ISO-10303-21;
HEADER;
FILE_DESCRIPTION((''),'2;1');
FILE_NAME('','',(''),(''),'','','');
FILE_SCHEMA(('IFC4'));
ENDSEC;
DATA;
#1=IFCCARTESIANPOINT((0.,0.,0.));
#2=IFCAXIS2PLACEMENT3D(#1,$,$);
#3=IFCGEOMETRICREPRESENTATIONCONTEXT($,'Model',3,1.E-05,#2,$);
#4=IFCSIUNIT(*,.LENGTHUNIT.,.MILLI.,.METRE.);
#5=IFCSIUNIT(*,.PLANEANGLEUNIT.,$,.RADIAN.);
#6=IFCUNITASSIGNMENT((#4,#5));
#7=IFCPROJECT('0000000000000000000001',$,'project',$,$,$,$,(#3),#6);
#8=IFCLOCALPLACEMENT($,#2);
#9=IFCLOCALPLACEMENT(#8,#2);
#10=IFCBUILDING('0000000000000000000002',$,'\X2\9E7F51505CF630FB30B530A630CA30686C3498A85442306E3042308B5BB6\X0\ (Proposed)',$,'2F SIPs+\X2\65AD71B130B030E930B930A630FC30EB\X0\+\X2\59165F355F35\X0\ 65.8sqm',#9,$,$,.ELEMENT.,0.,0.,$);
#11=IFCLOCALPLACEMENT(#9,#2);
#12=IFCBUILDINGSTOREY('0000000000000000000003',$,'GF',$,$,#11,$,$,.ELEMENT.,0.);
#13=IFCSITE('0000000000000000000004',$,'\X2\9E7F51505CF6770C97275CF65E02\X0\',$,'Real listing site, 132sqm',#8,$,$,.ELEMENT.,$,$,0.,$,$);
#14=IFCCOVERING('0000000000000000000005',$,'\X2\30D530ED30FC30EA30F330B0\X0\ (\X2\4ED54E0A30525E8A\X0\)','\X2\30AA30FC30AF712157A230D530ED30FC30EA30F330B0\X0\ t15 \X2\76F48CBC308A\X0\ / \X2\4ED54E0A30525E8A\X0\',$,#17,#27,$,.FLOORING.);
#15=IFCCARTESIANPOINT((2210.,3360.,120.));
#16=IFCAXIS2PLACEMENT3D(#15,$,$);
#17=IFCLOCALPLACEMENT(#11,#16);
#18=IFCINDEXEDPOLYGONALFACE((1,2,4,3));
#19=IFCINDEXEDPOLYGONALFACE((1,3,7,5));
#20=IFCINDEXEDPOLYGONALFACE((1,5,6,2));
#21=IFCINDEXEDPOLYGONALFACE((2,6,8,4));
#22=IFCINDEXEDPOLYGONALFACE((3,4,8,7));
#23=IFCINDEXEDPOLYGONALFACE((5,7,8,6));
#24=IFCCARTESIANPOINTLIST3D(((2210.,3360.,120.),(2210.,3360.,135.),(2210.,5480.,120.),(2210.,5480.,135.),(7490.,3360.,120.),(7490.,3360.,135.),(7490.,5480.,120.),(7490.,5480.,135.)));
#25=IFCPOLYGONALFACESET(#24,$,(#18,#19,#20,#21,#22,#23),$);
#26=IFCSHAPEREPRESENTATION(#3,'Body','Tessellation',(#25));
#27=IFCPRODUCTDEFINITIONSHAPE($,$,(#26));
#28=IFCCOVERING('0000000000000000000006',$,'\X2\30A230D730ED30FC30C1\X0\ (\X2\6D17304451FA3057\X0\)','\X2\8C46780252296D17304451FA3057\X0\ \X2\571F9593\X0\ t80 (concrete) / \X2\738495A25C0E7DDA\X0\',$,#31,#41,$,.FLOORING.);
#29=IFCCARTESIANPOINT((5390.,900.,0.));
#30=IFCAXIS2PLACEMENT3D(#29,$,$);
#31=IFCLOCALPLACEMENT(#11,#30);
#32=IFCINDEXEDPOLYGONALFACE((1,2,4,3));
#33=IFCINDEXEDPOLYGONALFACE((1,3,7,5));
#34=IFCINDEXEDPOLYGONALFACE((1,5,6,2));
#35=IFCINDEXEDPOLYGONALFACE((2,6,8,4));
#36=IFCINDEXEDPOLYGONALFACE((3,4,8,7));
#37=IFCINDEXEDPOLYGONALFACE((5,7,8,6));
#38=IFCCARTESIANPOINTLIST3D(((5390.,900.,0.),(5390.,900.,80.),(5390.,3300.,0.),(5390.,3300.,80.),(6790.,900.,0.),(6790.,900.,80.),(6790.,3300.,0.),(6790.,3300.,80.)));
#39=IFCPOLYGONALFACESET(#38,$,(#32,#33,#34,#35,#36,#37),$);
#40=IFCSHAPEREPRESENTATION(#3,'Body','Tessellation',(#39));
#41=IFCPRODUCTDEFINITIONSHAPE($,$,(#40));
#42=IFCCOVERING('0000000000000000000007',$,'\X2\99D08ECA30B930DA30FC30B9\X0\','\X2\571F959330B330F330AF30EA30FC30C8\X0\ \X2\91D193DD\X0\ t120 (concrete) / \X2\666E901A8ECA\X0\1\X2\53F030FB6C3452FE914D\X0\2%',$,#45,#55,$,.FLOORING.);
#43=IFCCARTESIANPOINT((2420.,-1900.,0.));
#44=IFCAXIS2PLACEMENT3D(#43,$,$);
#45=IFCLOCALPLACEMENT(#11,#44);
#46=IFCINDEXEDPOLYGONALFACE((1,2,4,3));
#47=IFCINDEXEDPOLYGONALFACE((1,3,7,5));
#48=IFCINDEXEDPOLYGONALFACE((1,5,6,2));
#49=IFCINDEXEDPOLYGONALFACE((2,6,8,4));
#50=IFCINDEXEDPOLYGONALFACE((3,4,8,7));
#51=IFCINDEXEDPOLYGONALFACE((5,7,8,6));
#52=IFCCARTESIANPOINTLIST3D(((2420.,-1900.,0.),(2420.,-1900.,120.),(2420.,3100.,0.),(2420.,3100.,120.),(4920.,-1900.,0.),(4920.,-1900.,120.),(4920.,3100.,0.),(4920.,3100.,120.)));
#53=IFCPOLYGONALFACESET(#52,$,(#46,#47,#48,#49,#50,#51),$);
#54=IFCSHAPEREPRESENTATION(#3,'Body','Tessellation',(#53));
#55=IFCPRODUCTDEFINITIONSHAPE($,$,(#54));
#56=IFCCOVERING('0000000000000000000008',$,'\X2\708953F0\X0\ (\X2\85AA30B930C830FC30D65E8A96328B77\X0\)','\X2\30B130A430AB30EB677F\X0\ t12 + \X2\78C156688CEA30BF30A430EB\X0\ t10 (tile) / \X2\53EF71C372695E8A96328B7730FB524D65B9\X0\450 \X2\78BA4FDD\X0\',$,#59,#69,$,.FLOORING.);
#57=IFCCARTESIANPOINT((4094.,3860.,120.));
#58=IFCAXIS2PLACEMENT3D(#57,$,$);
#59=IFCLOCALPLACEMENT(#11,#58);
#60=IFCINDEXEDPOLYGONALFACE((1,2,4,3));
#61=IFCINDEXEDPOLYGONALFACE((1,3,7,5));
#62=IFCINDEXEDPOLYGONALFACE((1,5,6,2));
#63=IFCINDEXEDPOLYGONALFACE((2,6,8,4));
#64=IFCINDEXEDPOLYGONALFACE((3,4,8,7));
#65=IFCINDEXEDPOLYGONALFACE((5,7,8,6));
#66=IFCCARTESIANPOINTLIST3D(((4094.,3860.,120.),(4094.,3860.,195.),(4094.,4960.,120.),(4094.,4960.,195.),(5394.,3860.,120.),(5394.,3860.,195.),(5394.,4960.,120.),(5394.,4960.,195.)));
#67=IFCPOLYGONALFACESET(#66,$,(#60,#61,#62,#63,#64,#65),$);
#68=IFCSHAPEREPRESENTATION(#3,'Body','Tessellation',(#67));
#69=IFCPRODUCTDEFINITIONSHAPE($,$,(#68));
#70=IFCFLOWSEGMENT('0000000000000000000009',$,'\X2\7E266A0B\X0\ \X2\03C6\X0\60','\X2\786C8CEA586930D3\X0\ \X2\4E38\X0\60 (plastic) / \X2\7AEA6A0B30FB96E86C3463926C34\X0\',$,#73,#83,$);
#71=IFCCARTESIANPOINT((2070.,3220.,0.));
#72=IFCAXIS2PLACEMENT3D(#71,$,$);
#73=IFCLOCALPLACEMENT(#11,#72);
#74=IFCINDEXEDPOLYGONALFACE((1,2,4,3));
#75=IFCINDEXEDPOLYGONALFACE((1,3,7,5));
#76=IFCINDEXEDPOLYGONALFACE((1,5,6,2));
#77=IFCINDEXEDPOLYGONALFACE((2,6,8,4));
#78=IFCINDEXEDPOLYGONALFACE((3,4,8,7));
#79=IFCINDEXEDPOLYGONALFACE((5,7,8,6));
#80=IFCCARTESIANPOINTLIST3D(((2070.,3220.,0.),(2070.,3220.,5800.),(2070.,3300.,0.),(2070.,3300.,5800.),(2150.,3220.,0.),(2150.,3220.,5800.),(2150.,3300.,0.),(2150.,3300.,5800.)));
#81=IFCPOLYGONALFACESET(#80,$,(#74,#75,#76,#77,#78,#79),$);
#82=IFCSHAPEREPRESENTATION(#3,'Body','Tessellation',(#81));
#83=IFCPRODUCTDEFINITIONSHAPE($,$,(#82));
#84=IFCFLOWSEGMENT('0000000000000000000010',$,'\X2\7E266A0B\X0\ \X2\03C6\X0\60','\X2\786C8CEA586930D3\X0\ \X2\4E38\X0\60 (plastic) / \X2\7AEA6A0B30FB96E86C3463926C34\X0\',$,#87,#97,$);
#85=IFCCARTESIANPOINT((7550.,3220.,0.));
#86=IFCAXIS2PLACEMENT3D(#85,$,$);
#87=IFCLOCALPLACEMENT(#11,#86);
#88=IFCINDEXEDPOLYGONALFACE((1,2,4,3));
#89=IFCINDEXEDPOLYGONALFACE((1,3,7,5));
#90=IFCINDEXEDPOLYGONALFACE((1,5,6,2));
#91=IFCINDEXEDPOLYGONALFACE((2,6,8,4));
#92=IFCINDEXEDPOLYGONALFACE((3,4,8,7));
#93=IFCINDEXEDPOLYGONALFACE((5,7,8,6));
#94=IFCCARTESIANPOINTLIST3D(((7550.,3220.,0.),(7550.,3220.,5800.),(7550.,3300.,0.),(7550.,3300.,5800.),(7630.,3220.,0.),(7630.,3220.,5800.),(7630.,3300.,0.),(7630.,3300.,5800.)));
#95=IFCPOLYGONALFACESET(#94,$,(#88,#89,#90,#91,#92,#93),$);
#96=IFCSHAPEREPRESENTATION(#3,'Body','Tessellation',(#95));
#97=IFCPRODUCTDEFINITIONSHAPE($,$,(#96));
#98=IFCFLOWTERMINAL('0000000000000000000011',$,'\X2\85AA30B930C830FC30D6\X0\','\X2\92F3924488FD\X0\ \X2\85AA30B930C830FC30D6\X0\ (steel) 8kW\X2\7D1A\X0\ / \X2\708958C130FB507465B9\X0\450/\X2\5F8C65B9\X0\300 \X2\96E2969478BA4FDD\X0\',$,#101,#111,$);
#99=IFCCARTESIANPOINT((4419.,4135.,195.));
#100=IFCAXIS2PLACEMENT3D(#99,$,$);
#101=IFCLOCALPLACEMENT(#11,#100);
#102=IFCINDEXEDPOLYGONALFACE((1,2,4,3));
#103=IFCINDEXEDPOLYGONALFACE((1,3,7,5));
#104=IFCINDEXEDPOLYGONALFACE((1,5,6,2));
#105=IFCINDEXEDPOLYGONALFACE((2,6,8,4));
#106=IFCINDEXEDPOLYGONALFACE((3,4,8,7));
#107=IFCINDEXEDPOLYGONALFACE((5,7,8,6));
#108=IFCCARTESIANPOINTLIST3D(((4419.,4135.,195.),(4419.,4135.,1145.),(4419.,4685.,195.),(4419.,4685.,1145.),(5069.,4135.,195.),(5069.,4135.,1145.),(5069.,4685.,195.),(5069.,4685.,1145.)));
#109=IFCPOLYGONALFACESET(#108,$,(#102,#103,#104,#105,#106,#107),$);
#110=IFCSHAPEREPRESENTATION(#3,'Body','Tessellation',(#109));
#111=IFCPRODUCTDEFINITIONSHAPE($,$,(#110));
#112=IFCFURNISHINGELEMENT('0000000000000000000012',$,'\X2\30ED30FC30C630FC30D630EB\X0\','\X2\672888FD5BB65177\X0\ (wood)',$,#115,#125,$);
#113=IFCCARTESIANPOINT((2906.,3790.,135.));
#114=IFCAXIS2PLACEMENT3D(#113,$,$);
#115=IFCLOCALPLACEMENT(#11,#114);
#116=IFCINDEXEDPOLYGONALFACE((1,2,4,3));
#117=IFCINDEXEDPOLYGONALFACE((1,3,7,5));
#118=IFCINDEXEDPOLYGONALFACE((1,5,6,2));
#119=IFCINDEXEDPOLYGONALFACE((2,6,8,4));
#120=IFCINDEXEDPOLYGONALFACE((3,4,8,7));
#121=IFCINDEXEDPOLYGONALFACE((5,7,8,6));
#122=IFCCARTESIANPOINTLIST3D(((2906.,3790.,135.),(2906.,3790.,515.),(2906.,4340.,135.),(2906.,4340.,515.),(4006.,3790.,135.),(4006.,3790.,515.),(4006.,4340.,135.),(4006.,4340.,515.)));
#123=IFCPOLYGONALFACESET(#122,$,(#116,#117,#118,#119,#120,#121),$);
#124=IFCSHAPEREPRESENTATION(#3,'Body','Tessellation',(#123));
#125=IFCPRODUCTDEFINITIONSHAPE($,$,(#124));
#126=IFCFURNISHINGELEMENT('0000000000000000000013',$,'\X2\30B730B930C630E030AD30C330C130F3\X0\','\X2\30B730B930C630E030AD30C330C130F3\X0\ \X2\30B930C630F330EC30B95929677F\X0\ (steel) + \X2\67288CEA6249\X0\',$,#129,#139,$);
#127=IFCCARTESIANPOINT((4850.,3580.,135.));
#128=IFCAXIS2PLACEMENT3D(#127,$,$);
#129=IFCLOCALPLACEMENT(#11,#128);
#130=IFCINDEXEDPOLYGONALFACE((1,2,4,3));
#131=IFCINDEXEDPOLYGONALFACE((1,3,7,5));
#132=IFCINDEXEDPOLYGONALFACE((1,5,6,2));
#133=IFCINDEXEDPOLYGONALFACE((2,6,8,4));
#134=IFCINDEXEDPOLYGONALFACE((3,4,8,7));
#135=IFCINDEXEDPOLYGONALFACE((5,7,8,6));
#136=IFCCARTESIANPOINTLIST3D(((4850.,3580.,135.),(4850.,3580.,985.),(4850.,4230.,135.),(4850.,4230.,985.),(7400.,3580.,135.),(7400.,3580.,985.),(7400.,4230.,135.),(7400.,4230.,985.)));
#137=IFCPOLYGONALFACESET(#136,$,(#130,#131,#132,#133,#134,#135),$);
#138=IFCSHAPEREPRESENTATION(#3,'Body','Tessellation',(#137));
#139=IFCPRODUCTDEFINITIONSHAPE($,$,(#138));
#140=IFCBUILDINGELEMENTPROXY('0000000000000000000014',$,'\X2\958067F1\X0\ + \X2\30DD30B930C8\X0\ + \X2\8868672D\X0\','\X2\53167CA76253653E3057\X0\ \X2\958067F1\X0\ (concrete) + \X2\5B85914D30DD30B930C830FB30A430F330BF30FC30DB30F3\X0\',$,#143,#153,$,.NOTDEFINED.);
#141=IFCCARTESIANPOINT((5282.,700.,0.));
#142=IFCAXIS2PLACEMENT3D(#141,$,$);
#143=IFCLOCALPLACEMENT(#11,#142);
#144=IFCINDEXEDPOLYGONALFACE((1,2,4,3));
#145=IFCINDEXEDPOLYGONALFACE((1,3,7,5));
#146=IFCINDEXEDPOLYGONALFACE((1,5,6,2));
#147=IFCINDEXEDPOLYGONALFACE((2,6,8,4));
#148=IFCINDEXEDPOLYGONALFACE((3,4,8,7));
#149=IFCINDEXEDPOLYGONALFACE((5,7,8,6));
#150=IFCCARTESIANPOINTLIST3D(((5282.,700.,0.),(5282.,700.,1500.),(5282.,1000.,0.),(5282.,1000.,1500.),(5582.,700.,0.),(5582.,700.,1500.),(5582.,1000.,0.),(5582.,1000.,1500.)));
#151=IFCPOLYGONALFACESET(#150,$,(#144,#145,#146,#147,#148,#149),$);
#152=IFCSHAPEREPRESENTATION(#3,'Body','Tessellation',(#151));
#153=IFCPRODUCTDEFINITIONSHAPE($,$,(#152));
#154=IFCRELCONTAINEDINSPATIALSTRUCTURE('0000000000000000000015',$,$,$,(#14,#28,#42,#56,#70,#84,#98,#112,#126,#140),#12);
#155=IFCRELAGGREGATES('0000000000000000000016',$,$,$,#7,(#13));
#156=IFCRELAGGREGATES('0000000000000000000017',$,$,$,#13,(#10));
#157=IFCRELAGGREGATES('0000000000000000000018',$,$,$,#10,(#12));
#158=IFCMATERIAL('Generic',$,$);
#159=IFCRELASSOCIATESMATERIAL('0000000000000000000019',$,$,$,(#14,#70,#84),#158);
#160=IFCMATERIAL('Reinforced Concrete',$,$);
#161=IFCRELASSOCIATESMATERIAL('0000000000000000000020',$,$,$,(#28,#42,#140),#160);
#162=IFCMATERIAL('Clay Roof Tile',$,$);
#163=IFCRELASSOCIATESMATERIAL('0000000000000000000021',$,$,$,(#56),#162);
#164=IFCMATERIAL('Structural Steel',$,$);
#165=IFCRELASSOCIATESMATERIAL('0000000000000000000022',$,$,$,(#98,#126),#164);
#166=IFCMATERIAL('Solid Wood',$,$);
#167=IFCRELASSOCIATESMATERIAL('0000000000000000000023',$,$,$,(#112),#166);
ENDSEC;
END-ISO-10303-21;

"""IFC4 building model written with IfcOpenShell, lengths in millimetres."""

from ifc_helpers import new_model, si_unit, frame, frame_2d, origin, place, context, project, spatial, rectangle, extrude, material, element, save


model = new_model("IFC4")

# Units and contexts
model_context = context("Model", 3, precision=1e-05, world=origin())
ifc_project = project(units=[si_unit("LENGTHUNIT", "METRE", prefix="MILLI"), si_unit("PLANEANGLEUNIT", "RADIAN")], contexts=[model_context])

# Site, building, storey
site_placement = place(None, origin())
site = spatial("IfcSite", under=ifc_project, at=site_placement, Name="鹿児島県霧島市", ObjectType="Real listing site, 132sqm", CompositionType="ELEMENT", RefElevation=0.0)
building_placement = place(site_placement, origin())
building = spatial("IfcBuilding", under=site, at=building_placement, Name="鹿児島・サウナと水風呂のある家 (Proposed)", ObjectType="2F SIPs+断熱グラスウール+外張張 65.8sqm", CompositionType="ELEMENT", ElevationOfRefHeight=0.0, ElevationOfTerrain=0.0)
storey_placement = place(building_placement, origin())
storey = spatial("IfcBuildingStorey", under=building, at=storey_placement, Name="GF", CompositionType="ELEMENT", Elevation=0.0)

# Shared definitions
ifc_material_1 = material(Name="Solid Wood")

# Shared definitions
ifc_material_2 = material(Name="Reinforced Concrete")

# Coverings
ifc_material_3 = material(Name="Generic")
covering_1_placement = place(storey_placement, frame((2210.0, 3360.0, 120.0)))
element("IfcCovering", 1, at=covering_1_placement, inside=storey, material=ifc_material_3, Name="フローリング (仕上げ床)", Description="オーク無垢フローリング t15 直貼り / 仕上げ床", PredefinedType="FLOORING", context=model_context, shape_type="SweptSolid", body=[
    extrude(rectangle(XDim=5280.0, YDim=2120.0, at=frame_2d((2640.0, 1060.0))), frame((2210.0, 3360.0, 120.0)), (0.0, 0.0, 1.0), 15.0),
])
covering_2_placement = place(storey_placement, frame((5390.0, 900.0, 0.0)))
element("IfcCovering", 2, at=covering_2_placement, inside=storey, material=ifc_material_2, Name="アプローチ (洗い出し)", Description="豆砂利洗い出し 土間 t80 (concrete) / 玄関導線", PredefinedType="FLOORING", context=model_context, shape_type="SweptSolid", body=[
    extrude(rectangle(XDim=1400.0, YDim=2400.0, at=frame_2d((700.0, 1200.0))), frame((5390.0, 900.0, 0.0)), (0.0, 0.0, 1.0), 80.0),
])
covering_3_placement = place(storey_placement, frame((2420.0, -1900.0, 0.0)))
element("IfcCovering", 3, at=covering_3_placement, inside=storey, material=ifc_material_2, Name="駐車スペース", Description="土間コンクリート 金鏝 t120 (concrete) / 普通車1台・水勾配2%", PredefinedType="FLOORING", context=model_context, shape_type="SweptSolid", body=[
    extrude(rectangle(XDim=2500.0, YDim=5000.0, at=frame_2d((1250.0, 2500.0))), frame((2420.0, -1900.0, 0.0)), (0.0, 0.0, 1.0), 120.0),
])
ifc_material_4 = material(Name="Clay Roof Tile")
covering_4_placement = place(storey_placement, frame((4094.0, 3860.0, 120.0)))
element("IfcCovering", 4, at=covering_4_placement, inside=storey, material=ifc_material_4, Name="炉台 (薪ストーブ床防護)", Description="ケイカル板 t12 + 磁器質タイル t10 (tile) / 可燃物床防護・前方450 確保", PredefinedType="FLOORING", context=model_context, shape_type="SweptSolid", body=[
    extrude(rectangle(XDim=1300.0, YDim=1100.0, at=frame_2d((650.0, 550.0))), frame((4094.0, 3860.0, 120.0)), (0.0, 0.0, 1.0), 75.0),
])

# Flow segments
flow_segment_1_placement = place(storey_placement, frame((2070.0, 3220.0, 0.0)))
element("IfcFlowSegment", 5, at=flow_segment_1_placement, inside=storey, material=ifc_material_3, Name="縦樋 φ60", Description="硬質塩ビ 丸60 (plastic) / 竪樋・雨水排水", context=model_context, shape_type="SweptSolid", body=[
    extrude(rectangle(XDim=80.0, YDim=80.0, at=frame_2d((40.0, 40.0))), frame((2070.0, 3220.0, 0.0)), (0.0, 0.0, 1.0), 5800.0),
])
flow_segment_2_placement = place(storey_placement, frame((7550.0, 3220.0, 0.0)))
element("IfcFlowSegment", 6, at=flow_segment_2_placement, inside=storey, material=ifc_material_3, Name="縦樋 φ60", Description="硬質塩ビ 丸60 (plastic) / 竪樋・雨水排水", context=model_context, shape_type="SweptSolid", body=[
    extrude(rectangle(XDim=80.0, YDim=80.0, at=frame_2d((40.0, 40.0))), frame((7550.0, 3220.0, 0.0)), (0.0, 0.0, 1.0), 5800.0),
])

# Flow terminal
ifc_material_5 = material(Name="Structural Steel")
flow_terminal_placement = place(storey_placement, frame((4419.0, 4135.0, 195.0)))
element("IfcFlowTerminal", 7, at=flow_terminal_placement, inside=storey, material=ifc_material_5, Name="薪ストーブ", Description="鋳鉄製 薪ストーブ (steel) 8kW級 / 炉壁・側方450/後方300 離隔確保", context=model_context, shape_type="SweptSolid", body=[
    extrude(rectangle(XDim=650.0, YDim=550.0, at=frame_2d((325.0, 275.0))), frame((4419.0, 4135.0, 195.0)), (0.0, 0.0, 1.0), 950.0),
])

# Furnishing elements
furnishing_1_placement = place(storey_placement, frame((2906.0, 3790.0, 135.0)))
element("IfcFurnishingElement", 8, at=furnishing_1_placement, inside=storey, material=ifc_material_1, Name="ローテーブル", Description="木製家具 (wood)", context=model_context, shape_type="SweptSolid", body=[
    extrude(rectangle(XDim=1100.0, YDim=550.0, at=frame_2d((550.0, 275.0))), frame((2906.0, 3790.0, 135.0)), (0.0, 0.0, 1.0), 380.0),
])
furnishing_2_placement = place(storey_placement, frame((4850.0, 3580.0, 135.0)))
element("IfcFurnishingElement", 9, at=furnishing_2_placement, inside=storey, material=ifc_material_5, Name="システムキッチン", Description="システムキッチン ステンレス天板 (steel) + 木質扉", context=model_context, shape_type="SweptSolid", body=[
    extrude(rectangle(XDim=2550.0, YDim=650.0, at=frame_2d((1275.0, 325.0))), frame((4850.0, 3580.0, 135.0)), (0.0, 0.0, 1.0), 850.0),
])

# Building element proxy
proxy_placement = place(storey_placement, frame((5282.0, 700.0, 0.0)))
element("IfcBuildingElementProxy", 10, at=proxy_placement, inside=storey, material=ifc_material_2, Name="門柱 + ポスト + 表札", Description="化粧打放し 門柱 (concrete) + 宅配ポスト・インターホン", PredefinedType="NOTDEFINED", context=model_context, shape_type="SweptSolid", body=[
    extrude(rectangle(XDim=300.0, YDim=300.0, at=frame_2d((150.0, 150.0))), frame((5282.0, 700.0, 0.0)), (0.0, 0.0, 1.0), 1500.0),
])

save(model, "model.ifc")
